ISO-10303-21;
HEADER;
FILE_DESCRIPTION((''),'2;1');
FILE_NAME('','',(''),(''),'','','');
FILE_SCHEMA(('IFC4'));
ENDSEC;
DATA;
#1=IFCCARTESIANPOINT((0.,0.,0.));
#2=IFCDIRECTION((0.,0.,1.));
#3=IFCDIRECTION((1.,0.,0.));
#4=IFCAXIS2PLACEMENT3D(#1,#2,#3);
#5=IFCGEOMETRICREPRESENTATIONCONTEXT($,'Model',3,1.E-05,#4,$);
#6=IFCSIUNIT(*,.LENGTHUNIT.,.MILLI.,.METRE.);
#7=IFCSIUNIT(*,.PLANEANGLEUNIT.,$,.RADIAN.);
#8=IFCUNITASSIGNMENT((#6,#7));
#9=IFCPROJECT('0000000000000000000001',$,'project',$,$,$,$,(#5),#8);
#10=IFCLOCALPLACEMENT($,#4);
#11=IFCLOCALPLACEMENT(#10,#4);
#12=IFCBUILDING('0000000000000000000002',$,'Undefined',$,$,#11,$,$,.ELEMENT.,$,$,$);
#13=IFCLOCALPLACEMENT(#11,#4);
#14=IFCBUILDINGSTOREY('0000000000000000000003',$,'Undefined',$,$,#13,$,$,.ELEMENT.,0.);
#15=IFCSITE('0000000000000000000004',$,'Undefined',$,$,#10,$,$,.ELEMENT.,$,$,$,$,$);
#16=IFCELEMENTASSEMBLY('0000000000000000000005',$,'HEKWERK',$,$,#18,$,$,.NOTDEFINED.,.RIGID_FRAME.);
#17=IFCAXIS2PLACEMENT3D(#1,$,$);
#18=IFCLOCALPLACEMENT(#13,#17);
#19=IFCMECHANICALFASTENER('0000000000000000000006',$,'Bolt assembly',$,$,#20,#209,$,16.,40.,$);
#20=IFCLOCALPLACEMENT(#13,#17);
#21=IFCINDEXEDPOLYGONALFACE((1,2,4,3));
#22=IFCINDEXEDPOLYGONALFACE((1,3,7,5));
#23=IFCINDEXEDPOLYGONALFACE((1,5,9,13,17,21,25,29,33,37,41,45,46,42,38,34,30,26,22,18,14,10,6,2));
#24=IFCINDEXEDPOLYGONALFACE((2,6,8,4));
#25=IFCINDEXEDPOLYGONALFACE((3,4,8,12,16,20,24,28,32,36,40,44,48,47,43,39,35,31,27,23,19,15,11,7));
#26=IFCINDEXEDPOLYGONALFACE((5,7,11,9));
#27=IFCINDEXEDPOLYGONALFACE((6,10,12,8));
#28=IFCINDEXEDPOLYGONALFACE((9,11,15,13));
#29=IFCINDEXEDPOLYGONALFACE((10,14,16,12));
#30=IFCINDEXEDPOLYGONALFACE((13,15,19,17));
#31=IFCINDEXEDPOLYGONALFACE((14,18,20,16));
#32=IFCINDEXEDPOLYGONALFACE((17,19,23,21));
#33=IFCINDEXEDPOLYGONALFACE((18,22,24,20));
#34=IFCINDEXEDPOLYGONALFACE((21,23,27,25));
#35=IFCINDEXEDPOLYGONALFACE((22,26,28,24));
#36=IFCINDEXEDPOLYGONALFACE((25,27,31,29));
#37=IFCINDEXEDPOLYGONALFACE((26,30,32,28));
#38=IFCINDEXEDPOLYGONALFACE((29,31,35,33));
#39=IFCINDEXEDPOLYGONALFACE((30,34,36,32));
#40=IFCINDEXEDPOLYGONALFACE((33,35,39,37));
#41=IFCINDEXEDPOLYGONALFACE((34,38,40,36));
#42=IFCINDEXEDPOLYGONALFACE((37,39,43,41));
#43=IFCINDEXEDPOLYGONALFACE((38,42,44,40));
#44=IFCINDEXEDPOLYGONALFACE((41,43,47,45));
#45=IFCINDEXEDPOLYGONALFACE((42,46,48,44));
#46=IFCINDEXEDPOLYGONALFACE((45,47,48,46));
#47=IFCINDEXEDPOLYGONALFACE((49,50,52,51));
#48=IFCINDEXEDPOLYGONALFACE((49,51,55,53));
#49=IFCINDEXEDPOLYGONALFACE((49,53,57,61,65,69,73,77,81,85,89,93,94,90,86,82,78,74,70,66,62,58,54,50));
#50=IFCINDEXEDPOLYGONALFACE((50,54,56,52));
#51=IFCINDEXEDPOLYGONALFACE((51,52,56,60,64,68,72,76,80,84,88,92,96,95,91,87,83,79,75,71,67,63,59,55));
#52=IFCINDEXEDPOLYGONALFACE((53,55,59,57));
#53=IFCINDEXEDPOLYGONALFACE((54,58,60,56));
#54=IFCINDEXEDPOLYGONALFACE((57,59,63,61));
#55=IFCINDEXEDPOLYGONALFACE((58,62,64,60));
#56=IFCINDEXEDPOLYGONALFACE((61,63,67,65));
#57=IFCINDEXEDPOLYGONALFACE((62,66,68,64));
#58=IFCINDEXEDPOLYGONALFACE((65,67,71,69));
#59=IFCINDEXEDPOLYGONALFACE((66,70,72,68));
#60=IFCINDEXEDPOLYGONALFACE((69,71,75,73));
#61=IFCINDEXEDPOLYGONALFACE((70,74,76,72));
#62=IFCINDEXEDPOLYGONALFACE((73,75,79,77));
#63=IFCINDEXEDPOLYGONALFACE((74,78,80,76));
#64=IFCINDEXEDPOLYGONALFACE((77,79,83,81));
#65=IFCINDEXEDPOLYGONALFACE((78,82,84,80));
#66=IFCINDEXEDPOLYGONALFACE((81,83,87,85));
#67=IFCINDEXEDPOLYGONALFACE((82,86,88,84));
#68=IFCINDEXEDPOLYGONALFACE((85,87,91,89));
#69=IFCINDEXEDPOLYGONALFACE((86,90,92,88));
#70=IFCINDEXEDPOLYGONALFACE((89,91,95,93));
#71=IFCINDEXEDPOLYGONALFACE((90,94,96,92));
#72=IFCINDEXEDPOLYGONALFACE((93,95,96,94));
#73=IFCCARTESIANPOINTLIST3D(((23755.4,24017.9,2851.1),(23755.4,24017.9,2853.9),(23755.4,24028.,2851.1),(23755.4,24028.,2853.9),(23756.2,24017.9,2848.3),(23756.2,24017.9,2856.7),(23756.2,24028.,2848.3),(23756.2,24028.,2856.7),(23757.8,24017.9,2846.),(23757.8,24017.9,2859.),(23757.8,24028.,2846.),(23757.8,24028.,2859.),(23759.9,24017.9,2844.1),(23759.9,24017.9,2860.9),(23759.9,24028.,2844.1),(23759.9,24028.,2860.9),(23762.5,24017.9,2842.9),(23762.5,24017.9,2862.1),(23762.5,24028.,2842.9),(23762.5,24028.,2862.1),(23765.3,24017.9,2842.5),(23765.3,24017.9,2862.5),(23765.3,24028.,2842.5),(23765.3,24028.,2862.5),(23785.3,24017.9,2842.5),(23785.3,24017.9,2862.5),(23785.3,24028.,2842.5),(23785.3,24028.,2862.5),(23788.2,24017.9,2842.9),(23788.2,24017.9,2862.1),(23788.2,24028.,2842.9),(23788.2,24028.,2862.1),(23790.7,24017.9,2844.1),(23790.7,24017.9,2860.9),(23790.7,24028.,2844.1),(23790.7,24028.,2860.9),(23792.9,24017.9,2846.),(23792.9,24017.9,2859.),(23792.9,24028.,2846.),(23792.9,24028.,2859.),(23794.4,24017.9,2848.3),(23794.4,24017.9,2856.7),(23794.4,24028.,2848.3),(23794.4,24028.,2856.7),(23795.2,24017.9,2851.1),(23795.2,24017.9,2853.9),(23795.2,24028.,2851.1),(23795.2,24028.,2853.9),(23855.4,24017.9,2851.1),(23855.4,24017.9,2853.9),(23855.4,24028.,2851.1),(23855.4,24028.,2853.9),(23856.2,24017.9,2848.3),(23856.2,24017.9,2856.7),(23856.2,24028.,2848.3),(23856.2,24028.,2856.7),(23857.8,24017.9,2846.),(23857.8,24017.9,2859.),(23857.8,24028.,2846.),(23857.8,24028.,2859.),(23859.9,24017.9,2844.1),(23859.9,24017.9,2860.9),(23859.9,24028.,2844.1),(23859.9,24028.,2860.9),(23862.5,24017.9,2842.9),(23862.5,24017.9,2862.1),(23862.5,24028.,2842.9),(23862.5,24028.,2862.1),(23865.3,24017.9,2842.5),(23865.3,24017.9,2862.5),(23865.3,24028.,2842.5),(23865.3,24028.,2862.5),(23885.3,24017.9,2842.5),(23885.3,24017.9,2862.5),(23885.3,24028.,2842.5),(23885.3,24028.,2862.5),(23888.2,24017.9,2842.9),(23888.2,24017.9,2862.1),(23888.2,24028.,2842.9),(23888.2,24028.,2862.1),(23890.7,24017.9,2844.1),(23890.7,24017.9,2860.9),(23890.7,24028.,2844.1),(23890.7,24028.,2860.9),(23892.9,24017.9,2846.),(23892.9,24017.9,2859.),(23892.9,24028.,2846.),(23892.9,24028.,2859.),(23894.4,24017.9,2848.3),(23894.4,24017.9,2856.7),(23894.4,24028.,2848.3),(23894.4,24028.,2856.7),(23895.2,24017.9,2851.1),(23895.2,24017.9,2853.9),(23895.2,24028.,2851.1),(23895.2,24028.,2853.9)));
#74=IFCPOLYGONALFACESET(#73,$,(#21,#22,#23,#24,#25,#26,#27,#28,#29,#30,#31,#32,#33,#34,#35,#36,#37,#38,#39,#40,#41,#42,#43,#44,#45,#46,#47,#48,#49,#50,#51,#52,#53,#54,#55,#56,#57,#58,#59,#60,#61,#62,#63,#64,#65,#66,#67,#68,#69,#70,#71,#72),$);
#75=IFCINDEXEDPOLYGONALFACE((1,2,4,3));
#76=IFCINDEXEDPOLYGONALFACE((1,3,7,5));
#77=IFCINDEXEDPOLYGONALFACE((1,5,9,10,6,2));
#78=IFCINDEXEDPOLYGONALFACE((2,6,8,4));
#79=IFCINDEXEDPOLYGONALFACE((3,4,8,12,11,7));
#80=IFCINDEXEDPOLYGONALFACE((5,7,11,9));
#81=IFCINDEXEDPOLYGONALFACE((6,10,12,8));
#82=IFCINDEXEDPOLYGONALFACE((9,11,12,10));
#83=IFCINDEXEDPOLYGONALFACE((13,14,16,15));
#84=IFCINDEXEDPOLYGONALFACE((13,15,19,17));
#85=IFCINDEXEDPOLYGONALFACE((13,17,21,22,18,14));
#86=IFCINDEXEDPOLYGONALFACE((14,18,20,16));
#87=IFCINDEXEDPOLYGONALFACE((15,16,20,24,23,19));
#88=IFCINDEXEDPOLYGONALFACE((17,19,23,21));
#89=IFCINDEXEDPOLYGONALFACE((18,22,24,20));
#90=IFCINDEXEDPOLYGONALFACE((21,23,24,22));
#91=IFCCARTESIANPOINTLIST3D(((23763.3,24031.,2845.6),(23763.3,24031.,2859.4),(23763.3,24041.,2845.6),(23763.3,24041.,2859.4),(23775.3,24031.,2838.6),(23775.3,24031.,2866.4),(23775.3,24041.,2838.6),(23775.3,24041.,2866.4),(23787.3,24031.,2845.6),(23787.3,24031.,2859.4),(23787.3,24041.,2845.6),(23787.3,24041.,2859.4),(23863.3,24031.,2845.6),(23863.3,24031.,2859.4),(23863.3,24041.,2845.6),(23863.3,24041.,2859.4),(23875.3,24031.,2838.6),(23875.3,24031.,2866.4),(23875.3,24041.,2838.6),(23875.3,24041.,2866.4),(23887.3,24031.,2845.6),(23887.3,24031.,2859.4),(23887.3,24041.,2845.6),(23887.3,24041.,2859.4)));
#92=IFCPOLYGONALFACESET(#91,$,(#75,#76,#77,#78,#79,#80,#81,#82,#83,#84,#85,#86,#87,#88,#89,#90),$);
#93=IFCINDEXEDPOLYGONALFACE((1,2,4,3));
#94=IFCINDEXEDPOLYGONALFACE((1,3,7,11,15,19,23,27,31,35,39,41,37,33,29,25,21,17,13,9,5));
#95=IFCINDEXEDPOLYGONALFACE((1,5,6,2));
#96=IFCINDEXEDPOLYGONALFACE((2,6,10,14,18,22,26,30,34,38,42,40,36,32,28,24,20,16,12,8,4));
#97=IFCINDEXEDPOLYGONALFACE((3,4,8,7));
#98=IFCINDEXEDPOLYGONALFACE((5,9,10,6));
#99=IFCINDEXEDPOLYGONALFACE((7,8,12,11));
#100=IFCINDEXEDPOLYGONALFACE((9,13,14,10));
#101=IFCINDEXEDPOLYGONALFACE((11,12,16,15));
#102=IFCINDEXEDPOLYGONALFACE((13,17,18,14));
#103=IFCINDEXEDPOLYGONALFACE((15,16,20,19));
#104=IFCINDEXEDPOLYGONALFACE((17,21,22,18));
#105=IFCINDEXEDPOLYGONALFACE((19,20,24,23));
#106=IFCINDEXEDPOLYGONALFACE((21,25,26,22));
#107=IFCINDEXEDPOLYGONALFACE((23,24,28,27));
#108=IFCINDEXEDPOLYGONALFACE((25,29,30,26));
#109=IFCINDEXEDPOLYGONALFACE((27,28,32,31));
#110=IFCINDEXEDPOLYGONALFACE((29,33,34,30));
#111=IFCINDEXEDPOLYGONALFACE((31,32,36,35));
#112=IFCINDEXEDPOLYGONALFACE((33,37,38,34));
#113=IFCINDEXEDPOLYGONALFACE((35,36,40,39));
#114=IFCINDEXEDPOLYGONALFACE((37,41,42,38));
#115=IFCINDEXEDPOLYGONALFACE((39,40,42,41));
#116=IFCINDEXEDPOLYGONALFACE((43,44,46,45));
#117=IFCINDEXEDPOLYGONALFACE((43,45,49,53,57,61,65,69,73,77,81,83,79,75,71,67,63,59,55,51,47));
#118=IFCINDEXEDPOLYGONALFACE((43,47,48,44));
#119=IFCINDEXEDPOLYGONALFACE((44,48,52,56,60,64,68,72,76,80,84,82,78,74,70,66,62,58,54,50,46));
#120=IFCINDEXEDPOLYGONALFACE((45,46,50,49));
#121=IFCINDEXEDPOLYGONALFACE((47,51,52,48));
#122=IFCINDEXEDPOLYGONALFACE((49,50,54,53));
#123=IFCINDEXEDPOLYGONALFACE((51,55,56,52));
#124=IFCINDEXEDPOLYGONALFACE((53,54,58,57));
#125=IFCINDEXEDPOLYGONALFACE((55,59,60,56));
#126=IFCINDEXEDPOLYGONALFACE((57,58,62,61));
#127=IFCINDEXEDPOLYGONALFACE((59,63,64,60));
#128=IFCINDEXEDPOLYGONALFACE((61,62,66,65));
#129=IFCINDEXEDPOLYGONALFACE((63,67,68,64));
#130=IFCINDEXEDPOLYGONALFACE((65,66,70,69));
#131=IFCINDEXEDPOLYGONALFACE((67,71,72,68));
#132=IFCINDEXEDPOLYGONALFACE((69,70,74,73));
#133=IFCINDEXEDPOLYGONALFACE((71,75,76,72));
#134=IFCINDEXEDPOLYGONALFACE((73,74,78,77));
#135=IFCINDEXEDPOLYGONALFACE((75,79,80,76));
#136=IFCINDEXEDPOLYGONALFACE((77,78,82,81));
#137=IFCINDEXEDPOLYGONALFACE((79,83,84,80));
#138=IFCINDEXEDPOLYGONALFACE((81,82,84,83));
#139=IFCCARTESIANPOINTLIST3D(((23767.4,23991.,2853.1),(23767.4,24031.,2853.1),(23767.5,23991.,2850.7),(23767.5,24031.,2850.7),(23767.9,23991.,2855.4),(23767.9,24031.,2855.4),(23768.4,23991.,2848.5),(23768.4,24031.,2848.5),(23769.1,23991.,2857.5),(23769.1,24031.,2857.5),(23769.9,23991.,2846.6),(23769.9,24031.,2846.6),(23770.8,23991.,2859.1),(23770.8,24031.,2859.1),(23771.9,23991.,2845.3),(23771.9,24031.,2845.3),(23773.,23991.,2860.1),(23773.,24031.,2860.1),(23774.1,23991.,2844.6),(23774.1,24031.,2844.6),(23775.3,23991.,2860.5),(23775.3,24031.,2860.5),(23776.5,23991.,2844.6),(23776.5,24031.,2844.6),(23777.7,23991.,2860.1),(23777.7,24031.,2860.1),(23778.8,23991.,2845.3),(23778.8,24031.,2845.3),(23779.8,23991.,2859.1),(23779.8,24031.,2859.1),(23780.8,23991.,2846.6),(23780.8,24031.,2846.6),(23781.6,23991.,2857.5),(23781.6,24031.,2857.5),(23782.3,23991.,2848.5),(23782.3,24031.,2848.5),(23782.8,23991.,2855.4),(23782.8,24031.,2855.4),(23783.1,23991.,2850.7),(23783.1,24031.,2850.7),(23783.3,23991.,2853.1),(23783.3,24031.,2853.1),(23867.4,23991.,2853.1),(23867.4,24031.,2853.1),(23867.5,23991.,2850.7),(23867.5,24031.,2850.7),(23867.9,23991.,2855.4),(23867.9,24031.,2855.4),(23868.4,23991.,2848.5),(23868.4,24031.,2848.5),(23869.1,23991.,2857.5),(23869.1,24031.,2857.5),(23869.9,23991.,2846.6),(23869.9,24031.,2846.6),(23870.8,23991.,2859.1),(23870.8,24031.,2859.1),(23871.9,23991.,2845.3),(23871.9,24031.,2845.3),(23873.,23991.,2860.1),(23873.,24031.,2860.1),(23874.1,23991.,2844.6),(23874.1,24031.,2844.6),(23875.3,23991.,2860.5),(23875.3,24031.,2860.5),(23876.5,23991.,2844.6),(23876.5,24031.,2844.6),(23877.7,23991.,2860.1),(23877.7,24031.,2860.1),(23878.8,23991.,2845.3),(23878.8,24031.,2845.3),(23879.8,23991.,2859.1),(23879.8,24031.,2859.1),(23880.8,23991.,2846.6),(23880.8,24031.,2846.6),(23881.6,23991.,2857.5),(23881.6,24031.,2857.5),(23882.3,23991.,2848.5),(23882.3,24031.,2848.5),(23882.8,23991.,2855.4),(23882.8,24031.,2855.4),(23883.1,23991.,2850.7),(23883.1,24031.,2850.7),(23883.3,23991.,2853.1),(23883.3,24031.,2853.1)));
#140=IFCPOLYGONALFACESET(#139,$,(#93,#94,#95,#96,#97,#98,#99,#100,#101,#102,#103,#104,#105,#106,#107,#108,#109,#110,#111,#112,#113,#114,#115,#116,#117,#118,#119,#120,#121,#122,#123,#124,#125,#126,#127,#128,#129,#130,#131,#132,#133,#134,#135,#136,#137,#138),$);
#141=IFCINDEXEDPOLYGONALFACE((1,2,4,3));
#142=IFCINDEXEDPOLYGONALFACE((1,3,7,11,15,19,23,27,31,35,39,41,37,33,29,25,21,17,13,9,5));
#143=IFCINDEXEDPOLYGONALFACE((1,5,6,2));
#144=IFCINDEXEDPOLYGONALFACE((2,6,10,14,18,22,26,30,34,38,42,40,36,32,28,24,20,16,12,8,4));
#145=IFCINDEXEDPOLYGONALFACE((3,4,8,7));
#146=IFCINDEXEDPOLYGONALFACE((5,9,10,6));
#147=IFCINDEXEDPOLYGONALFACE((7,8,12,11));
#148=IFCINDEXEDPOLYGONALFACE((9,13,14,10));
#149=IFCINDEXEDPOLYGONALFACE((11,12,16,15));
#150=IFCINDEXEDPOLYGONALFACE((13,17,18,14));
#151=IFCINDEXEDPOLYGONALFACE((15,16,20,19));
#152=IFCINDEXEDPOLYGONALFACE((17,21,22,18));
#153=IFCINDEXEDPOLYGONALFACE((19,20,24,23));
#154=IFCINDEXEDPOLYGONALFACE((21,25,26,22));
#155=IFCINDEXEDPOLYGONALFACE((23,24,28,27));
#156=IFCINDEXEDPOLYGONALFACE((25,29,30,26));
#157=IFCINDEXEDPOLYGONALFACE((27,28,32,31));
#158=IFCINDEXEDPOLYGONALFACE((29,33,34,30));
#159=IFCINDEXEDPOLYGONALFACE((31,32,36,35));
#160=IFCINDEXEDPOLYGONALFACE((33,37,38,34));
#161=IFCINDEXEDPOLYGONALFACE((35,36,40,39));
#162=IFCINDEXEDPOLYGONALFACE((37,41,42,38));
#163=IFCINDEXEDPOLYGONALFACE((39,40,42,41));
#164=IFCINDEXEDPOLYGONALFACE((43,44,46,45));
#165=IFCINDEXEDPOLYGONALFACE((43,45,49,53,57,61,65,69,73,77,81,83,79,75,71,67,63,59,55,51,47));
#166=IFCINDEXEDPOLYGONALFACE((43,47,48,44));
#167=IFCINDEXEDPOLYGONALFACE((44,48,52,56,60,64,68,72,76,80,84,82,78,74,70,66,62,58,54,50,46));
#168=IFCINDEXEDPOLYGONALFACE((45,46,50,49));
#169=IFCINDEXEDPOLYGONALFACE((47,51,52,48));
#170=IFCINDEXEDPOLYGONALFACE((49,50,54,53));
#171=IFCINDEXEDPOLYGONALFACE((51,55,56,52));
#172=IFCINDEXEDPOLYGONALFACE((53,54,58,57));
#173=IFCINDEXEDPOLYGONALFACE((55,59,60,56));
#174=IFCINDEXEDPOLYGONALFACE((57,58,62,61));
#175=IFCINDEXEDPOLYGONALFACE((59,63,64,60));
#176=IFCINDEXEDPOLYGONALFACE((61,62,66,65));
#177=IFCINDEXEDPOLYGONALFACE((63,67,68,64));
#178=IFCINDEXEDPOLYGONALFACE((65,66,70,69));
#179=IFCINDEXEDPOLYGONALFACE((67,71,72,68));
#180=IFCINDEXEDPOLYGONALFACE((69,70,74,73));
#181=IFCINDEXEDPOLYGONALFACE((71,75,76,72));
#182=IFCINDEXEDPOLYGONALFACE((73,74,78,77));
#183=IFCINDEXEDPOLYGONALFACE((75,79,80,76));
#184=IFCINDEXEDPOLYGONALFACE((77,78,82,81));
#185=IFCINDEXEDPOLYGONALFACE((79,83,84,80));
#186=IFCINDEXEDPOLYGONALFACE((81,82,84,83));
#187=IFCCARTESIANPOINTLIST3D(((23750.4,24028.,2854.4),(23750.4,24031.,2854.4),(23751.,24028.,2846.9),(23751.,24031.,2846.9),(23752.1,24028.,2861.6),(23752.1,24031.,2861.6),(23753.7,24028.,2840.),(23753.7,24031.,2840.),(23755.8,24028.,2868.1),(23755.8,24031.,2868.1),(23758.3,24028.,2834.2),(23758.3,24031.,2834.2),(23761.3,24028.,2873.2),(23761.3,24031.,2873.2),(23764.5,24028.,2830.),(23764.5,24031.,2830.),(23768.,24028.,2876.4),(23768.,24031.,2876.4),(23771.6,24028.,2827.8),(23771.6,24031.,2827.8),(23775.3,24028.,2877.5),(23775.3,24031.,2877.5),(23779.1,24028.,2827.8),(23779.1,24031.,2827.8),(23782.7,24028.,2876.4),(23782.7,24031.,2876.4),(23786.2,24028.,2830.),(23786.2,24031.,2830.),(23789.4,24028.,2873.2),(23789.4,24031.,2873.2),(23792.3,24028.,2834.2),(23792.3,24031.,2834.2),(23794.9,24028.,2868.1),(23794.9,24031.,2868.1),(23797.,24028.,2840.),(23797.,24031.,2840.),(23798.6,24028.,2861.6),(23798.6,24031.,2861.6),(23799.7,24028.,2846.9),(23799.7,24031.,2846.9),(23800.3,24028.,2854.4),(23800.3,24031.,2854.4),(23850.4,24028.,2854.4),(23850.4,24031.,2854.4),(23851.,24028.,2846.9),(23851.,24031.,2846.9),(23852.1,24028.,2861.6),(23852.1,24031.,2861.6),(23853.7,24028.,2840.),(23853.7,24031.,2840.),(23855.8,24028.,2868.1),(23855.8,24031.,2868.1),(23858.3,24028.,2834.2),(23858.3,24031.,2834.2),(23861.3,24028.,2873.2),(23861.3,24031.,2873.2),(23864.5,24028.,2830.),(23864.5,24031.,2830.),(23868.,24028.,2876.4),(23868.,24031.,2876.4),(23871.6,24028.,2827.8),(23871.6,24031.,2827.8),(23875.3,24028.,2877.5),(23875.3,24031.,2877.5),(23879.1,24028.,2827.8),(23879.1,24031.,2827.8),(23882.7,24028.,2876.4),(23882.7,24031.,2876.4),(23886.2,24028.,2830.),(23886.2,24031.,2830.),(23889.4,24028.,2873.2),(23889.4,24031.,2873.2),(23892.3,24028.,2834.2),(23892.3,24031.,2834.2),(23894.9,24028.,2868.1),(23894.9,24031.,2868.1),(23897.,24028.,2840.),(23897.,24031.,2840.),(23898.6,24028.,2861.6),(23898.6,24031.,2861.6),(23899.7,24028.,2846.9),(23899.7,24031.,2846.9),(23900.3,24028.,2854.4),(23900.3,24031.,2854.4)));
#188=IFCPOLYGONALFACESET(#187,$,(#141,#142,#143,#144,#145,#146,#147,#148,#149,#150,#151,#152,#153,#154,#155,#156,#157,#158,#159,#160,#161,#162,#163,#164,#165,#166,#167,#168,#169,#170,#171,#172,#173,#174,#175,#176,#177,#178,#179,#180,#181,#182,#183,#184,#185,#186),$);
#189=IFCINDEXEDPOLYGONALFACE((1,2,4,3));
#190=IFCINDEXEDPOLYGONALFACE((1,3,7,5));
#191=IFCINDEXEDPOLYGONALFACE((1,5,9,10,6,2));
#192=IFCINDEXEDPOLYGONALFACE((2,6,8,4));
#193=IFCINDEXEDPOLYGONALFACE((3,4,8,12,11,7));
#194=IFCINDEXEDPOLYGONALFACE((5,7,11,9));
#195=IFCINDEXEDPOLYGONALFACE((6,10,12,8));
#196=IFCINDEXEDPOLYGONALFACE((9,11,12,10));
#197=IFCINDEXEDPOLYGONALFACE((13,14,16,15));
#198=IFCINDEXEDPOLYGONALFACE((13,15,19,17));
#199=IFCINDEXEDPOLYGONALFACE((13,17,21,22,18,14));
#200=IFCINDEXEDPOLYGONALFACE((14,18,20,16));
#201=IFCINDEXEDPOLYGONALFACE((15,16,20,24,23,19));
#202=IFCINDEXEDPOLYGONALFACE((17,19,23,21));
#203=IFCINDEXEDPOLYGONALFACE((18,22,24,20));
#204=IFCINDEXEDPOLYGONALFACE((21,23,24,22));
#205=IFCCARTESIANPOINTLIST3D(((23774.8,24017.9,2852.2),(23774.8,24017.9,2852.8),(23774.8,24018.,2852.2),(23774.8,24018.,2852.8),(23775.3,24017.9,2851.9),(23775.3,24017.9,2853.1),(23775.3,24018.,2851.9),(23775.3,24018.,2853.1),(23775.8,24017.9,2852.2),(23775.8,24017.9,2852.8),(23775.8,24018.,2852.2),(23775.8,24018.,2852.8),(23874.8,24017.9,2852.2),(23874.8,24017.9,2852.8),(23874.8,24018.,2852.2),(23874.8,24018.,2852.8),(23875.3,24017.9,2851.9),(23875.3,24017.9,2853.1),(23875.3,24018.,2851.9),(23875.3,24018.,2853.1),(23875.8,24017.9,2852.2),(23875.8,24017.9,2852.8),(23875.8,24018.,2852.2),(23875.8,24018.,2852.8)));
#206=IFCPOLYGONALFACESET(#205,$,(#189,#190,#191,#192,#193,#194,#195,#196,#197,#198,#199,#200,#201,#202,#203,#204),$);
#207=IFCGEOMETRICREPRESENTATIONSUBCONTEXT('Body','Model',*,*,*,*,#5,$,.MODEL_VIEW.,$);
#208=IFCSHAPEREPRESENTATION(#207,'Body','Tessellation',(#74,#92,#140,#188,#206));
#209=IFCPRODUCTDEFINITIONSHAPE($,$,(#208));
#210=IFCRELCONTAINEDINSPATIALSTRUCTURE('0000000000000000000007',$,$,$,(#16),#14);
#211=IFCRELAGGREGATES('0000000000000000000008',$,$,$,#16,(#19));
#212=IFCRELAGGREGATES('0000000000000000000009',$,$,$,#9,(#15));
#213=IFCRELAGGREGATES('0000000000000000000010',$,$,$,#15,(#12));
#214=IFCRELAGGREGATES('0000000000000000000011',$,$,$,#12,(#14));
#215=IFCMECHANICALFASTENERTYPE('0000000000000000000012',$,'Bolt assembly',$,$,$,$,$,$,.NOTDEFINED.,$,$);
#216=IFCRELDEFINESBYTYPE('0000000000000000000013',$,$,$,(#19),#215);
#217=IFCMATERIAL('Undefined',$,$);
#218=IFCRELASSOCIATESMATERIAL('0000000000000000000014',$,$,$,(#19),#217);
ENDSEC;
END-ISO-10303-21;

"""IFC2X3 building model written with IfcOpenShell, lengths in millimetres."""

from ifc_helpers import new_model, si_unit, frame, frame_2d, origin_with_axes, origin_2d_with_axis, place, context, subcontext, project, spatial, polyline, circle_curve, parameter, trimmed, segment, composite_curve, circle, outline, extrude, source, transform, mapped, material, type_object, element, aggregate, save


model = new_model("IFC2X3")

# Units and contexts
model_context = context("Model", 3, precision=1e-05, world=origin_with_axes())
body_context = subcontext(model_context, "Body", "Model", "MODEL_VIEW")
ifc_project = project(units=[si_unit("LENGTHUNIT", "METRE", prefix="MILLI"), si_unit("PLANEANGLEUNIT", "RADIAN")], contexts=[model_context])

# Site, building, storey
site_placement = place(None, origin_with_axes())
site = spatial("IfcSite", under=ifc_project, at=site_placement, Name="Undefined", CompositionType="ELEMENT")
building_placement = place(site_placement, origin_with_axes())
building = spatial("IfcBuilding", under=site, at=building_placement, Name="Undefined", CompositionType="ELEMENT")
storey_placement = place(building_placement, origin_with_axes())
storey = spatial("IfcBuildingStorey", under=building, at=storey_placement, Name="Undefined", CompositionType="ELEMENT", Elevation=0.0)

# Element assembly
assembly_1_placement = place(storey_placement, origin_with_axes())
assembly_1 = element("IfcElementAssembly", 1, at=assembly_1_placement, inside=storey, Name="HEKWERK", AssemblyPlace="NOTDEFINED", PredefinedType="RIGID_FRAME")
ifc_material_1 = material(Name="Undefined")
mechanical_fastener_type = type_object("IfcMechanicalFastenerType", Name="Bolt assembly")

# Mechanical fastener
shared_shape_1 = source(origin_with_axes(), body_context, "Body", "SweptSolid", [
    extrude(outline(composite_curve([segment(polyline([(10.0, 10.0), (10.0, -10.0)]), True, "CONTINUOUS"), segment(trimmed(circle_curve(frame_2d((0.0, -10.0), x_axis=(1.0, 0.0)), 10.0), [parameter(0.0)], [parameter(3.141593)], False, "PARAMETER"), True, "CONTINUOUS"), segment(polyline([(-10.0, -10.0), (-10.0, 10.0)]), True, "CONTINUOUS"), segment(trimmed(circle_curve(frame_2d((0.0, 10.0), x_axis=(-1.0, 0.0)), 10.0), [parameter(0.0)], [parameter(3.141593)], False, "PARAMETER"), True, "DISCONTINUOUS")], self_intersect=False)), frame((0.0, 30.0, 0.0), z_axis=(0.0, 1.0, 0.0), x_axis=(1.0, 0.0, 0.0)), (0.0, 0.0, 1.0), 10.1),
    extrude(outline(polyline([(13.9, 0.0), (6.9, 12.0), (-6.9, 12.0), (-13.9, 0.0), (-6.9, -12.0), (6.9, -12.0), (13.9, 0.0)])), frame((0.0, 17.0, 0.0), z_axis=(0.0, 1.0, 0.0), x_axis=(1.0, 0.0, 0.0)), (0.0, 0.0, 1.0), 10.0),
    extrude(circle(Radius=8.0, at=origin_2d_with_axis()), frame((0.0, 27.0, 0.0), z_axis=(0.0, 1.0, 0.0), x_axis=(1.0, 0.0, 0.0)), (0.0, 0.0, 1.0), 40.0),
    extrude(circle(Radius=25.0, at=origin_2d_with_axis()), frame((0.0, 27.0, 0.0), z_axis=(0.0, 1.0, 0.0), x_axis=(1.0, 0.0, 0.0)), (0.0, 0.0, 1.0), 3.0),
    extrude(outline(polyline([(0.6, 0.0), (0.3, 0.5), (-0.3, 0.5), (-0.6, 0.0), (-0.3, -0.5), (0.3, -0.5), (0.6, 0.0)])), frame((0.0, 40.0, 0.0), z_axis=(0.0, 1.0, 0.0), x_axis=(1.0, 0.0, 0.0)), (0.0, 0.0, 1.0), 0.1),
])
mechanical_fastener_1_placement = place(assembly_1_placement, frame((23825.3, 24058.0, 2852.5), z_axis=(1.0, 0.0, 0.0), x_axis=(0.0, 0.0, 1.0)))
mechanical_fastener_1 = element("IfcMechanicalFastener", 2, at=mechanical_fastener_1_placement, type_object=mechanical_fastener_type, material=ifc_material_1, Name="Bolt assembly", NominalDiameter=16.0, NominalLength=40.0, context=body_context, shape_type="MappedRepresentation", body=[
    mapped(shared_shape_1, transform((0.0, 0.0, -50.0))),
    mapped(shared_shape_1, transform((0.0, 0.0, 50.0))),
])
aggregate(assembly_1, [mechanical_fastener_1])

save(model, "model.ifc")
